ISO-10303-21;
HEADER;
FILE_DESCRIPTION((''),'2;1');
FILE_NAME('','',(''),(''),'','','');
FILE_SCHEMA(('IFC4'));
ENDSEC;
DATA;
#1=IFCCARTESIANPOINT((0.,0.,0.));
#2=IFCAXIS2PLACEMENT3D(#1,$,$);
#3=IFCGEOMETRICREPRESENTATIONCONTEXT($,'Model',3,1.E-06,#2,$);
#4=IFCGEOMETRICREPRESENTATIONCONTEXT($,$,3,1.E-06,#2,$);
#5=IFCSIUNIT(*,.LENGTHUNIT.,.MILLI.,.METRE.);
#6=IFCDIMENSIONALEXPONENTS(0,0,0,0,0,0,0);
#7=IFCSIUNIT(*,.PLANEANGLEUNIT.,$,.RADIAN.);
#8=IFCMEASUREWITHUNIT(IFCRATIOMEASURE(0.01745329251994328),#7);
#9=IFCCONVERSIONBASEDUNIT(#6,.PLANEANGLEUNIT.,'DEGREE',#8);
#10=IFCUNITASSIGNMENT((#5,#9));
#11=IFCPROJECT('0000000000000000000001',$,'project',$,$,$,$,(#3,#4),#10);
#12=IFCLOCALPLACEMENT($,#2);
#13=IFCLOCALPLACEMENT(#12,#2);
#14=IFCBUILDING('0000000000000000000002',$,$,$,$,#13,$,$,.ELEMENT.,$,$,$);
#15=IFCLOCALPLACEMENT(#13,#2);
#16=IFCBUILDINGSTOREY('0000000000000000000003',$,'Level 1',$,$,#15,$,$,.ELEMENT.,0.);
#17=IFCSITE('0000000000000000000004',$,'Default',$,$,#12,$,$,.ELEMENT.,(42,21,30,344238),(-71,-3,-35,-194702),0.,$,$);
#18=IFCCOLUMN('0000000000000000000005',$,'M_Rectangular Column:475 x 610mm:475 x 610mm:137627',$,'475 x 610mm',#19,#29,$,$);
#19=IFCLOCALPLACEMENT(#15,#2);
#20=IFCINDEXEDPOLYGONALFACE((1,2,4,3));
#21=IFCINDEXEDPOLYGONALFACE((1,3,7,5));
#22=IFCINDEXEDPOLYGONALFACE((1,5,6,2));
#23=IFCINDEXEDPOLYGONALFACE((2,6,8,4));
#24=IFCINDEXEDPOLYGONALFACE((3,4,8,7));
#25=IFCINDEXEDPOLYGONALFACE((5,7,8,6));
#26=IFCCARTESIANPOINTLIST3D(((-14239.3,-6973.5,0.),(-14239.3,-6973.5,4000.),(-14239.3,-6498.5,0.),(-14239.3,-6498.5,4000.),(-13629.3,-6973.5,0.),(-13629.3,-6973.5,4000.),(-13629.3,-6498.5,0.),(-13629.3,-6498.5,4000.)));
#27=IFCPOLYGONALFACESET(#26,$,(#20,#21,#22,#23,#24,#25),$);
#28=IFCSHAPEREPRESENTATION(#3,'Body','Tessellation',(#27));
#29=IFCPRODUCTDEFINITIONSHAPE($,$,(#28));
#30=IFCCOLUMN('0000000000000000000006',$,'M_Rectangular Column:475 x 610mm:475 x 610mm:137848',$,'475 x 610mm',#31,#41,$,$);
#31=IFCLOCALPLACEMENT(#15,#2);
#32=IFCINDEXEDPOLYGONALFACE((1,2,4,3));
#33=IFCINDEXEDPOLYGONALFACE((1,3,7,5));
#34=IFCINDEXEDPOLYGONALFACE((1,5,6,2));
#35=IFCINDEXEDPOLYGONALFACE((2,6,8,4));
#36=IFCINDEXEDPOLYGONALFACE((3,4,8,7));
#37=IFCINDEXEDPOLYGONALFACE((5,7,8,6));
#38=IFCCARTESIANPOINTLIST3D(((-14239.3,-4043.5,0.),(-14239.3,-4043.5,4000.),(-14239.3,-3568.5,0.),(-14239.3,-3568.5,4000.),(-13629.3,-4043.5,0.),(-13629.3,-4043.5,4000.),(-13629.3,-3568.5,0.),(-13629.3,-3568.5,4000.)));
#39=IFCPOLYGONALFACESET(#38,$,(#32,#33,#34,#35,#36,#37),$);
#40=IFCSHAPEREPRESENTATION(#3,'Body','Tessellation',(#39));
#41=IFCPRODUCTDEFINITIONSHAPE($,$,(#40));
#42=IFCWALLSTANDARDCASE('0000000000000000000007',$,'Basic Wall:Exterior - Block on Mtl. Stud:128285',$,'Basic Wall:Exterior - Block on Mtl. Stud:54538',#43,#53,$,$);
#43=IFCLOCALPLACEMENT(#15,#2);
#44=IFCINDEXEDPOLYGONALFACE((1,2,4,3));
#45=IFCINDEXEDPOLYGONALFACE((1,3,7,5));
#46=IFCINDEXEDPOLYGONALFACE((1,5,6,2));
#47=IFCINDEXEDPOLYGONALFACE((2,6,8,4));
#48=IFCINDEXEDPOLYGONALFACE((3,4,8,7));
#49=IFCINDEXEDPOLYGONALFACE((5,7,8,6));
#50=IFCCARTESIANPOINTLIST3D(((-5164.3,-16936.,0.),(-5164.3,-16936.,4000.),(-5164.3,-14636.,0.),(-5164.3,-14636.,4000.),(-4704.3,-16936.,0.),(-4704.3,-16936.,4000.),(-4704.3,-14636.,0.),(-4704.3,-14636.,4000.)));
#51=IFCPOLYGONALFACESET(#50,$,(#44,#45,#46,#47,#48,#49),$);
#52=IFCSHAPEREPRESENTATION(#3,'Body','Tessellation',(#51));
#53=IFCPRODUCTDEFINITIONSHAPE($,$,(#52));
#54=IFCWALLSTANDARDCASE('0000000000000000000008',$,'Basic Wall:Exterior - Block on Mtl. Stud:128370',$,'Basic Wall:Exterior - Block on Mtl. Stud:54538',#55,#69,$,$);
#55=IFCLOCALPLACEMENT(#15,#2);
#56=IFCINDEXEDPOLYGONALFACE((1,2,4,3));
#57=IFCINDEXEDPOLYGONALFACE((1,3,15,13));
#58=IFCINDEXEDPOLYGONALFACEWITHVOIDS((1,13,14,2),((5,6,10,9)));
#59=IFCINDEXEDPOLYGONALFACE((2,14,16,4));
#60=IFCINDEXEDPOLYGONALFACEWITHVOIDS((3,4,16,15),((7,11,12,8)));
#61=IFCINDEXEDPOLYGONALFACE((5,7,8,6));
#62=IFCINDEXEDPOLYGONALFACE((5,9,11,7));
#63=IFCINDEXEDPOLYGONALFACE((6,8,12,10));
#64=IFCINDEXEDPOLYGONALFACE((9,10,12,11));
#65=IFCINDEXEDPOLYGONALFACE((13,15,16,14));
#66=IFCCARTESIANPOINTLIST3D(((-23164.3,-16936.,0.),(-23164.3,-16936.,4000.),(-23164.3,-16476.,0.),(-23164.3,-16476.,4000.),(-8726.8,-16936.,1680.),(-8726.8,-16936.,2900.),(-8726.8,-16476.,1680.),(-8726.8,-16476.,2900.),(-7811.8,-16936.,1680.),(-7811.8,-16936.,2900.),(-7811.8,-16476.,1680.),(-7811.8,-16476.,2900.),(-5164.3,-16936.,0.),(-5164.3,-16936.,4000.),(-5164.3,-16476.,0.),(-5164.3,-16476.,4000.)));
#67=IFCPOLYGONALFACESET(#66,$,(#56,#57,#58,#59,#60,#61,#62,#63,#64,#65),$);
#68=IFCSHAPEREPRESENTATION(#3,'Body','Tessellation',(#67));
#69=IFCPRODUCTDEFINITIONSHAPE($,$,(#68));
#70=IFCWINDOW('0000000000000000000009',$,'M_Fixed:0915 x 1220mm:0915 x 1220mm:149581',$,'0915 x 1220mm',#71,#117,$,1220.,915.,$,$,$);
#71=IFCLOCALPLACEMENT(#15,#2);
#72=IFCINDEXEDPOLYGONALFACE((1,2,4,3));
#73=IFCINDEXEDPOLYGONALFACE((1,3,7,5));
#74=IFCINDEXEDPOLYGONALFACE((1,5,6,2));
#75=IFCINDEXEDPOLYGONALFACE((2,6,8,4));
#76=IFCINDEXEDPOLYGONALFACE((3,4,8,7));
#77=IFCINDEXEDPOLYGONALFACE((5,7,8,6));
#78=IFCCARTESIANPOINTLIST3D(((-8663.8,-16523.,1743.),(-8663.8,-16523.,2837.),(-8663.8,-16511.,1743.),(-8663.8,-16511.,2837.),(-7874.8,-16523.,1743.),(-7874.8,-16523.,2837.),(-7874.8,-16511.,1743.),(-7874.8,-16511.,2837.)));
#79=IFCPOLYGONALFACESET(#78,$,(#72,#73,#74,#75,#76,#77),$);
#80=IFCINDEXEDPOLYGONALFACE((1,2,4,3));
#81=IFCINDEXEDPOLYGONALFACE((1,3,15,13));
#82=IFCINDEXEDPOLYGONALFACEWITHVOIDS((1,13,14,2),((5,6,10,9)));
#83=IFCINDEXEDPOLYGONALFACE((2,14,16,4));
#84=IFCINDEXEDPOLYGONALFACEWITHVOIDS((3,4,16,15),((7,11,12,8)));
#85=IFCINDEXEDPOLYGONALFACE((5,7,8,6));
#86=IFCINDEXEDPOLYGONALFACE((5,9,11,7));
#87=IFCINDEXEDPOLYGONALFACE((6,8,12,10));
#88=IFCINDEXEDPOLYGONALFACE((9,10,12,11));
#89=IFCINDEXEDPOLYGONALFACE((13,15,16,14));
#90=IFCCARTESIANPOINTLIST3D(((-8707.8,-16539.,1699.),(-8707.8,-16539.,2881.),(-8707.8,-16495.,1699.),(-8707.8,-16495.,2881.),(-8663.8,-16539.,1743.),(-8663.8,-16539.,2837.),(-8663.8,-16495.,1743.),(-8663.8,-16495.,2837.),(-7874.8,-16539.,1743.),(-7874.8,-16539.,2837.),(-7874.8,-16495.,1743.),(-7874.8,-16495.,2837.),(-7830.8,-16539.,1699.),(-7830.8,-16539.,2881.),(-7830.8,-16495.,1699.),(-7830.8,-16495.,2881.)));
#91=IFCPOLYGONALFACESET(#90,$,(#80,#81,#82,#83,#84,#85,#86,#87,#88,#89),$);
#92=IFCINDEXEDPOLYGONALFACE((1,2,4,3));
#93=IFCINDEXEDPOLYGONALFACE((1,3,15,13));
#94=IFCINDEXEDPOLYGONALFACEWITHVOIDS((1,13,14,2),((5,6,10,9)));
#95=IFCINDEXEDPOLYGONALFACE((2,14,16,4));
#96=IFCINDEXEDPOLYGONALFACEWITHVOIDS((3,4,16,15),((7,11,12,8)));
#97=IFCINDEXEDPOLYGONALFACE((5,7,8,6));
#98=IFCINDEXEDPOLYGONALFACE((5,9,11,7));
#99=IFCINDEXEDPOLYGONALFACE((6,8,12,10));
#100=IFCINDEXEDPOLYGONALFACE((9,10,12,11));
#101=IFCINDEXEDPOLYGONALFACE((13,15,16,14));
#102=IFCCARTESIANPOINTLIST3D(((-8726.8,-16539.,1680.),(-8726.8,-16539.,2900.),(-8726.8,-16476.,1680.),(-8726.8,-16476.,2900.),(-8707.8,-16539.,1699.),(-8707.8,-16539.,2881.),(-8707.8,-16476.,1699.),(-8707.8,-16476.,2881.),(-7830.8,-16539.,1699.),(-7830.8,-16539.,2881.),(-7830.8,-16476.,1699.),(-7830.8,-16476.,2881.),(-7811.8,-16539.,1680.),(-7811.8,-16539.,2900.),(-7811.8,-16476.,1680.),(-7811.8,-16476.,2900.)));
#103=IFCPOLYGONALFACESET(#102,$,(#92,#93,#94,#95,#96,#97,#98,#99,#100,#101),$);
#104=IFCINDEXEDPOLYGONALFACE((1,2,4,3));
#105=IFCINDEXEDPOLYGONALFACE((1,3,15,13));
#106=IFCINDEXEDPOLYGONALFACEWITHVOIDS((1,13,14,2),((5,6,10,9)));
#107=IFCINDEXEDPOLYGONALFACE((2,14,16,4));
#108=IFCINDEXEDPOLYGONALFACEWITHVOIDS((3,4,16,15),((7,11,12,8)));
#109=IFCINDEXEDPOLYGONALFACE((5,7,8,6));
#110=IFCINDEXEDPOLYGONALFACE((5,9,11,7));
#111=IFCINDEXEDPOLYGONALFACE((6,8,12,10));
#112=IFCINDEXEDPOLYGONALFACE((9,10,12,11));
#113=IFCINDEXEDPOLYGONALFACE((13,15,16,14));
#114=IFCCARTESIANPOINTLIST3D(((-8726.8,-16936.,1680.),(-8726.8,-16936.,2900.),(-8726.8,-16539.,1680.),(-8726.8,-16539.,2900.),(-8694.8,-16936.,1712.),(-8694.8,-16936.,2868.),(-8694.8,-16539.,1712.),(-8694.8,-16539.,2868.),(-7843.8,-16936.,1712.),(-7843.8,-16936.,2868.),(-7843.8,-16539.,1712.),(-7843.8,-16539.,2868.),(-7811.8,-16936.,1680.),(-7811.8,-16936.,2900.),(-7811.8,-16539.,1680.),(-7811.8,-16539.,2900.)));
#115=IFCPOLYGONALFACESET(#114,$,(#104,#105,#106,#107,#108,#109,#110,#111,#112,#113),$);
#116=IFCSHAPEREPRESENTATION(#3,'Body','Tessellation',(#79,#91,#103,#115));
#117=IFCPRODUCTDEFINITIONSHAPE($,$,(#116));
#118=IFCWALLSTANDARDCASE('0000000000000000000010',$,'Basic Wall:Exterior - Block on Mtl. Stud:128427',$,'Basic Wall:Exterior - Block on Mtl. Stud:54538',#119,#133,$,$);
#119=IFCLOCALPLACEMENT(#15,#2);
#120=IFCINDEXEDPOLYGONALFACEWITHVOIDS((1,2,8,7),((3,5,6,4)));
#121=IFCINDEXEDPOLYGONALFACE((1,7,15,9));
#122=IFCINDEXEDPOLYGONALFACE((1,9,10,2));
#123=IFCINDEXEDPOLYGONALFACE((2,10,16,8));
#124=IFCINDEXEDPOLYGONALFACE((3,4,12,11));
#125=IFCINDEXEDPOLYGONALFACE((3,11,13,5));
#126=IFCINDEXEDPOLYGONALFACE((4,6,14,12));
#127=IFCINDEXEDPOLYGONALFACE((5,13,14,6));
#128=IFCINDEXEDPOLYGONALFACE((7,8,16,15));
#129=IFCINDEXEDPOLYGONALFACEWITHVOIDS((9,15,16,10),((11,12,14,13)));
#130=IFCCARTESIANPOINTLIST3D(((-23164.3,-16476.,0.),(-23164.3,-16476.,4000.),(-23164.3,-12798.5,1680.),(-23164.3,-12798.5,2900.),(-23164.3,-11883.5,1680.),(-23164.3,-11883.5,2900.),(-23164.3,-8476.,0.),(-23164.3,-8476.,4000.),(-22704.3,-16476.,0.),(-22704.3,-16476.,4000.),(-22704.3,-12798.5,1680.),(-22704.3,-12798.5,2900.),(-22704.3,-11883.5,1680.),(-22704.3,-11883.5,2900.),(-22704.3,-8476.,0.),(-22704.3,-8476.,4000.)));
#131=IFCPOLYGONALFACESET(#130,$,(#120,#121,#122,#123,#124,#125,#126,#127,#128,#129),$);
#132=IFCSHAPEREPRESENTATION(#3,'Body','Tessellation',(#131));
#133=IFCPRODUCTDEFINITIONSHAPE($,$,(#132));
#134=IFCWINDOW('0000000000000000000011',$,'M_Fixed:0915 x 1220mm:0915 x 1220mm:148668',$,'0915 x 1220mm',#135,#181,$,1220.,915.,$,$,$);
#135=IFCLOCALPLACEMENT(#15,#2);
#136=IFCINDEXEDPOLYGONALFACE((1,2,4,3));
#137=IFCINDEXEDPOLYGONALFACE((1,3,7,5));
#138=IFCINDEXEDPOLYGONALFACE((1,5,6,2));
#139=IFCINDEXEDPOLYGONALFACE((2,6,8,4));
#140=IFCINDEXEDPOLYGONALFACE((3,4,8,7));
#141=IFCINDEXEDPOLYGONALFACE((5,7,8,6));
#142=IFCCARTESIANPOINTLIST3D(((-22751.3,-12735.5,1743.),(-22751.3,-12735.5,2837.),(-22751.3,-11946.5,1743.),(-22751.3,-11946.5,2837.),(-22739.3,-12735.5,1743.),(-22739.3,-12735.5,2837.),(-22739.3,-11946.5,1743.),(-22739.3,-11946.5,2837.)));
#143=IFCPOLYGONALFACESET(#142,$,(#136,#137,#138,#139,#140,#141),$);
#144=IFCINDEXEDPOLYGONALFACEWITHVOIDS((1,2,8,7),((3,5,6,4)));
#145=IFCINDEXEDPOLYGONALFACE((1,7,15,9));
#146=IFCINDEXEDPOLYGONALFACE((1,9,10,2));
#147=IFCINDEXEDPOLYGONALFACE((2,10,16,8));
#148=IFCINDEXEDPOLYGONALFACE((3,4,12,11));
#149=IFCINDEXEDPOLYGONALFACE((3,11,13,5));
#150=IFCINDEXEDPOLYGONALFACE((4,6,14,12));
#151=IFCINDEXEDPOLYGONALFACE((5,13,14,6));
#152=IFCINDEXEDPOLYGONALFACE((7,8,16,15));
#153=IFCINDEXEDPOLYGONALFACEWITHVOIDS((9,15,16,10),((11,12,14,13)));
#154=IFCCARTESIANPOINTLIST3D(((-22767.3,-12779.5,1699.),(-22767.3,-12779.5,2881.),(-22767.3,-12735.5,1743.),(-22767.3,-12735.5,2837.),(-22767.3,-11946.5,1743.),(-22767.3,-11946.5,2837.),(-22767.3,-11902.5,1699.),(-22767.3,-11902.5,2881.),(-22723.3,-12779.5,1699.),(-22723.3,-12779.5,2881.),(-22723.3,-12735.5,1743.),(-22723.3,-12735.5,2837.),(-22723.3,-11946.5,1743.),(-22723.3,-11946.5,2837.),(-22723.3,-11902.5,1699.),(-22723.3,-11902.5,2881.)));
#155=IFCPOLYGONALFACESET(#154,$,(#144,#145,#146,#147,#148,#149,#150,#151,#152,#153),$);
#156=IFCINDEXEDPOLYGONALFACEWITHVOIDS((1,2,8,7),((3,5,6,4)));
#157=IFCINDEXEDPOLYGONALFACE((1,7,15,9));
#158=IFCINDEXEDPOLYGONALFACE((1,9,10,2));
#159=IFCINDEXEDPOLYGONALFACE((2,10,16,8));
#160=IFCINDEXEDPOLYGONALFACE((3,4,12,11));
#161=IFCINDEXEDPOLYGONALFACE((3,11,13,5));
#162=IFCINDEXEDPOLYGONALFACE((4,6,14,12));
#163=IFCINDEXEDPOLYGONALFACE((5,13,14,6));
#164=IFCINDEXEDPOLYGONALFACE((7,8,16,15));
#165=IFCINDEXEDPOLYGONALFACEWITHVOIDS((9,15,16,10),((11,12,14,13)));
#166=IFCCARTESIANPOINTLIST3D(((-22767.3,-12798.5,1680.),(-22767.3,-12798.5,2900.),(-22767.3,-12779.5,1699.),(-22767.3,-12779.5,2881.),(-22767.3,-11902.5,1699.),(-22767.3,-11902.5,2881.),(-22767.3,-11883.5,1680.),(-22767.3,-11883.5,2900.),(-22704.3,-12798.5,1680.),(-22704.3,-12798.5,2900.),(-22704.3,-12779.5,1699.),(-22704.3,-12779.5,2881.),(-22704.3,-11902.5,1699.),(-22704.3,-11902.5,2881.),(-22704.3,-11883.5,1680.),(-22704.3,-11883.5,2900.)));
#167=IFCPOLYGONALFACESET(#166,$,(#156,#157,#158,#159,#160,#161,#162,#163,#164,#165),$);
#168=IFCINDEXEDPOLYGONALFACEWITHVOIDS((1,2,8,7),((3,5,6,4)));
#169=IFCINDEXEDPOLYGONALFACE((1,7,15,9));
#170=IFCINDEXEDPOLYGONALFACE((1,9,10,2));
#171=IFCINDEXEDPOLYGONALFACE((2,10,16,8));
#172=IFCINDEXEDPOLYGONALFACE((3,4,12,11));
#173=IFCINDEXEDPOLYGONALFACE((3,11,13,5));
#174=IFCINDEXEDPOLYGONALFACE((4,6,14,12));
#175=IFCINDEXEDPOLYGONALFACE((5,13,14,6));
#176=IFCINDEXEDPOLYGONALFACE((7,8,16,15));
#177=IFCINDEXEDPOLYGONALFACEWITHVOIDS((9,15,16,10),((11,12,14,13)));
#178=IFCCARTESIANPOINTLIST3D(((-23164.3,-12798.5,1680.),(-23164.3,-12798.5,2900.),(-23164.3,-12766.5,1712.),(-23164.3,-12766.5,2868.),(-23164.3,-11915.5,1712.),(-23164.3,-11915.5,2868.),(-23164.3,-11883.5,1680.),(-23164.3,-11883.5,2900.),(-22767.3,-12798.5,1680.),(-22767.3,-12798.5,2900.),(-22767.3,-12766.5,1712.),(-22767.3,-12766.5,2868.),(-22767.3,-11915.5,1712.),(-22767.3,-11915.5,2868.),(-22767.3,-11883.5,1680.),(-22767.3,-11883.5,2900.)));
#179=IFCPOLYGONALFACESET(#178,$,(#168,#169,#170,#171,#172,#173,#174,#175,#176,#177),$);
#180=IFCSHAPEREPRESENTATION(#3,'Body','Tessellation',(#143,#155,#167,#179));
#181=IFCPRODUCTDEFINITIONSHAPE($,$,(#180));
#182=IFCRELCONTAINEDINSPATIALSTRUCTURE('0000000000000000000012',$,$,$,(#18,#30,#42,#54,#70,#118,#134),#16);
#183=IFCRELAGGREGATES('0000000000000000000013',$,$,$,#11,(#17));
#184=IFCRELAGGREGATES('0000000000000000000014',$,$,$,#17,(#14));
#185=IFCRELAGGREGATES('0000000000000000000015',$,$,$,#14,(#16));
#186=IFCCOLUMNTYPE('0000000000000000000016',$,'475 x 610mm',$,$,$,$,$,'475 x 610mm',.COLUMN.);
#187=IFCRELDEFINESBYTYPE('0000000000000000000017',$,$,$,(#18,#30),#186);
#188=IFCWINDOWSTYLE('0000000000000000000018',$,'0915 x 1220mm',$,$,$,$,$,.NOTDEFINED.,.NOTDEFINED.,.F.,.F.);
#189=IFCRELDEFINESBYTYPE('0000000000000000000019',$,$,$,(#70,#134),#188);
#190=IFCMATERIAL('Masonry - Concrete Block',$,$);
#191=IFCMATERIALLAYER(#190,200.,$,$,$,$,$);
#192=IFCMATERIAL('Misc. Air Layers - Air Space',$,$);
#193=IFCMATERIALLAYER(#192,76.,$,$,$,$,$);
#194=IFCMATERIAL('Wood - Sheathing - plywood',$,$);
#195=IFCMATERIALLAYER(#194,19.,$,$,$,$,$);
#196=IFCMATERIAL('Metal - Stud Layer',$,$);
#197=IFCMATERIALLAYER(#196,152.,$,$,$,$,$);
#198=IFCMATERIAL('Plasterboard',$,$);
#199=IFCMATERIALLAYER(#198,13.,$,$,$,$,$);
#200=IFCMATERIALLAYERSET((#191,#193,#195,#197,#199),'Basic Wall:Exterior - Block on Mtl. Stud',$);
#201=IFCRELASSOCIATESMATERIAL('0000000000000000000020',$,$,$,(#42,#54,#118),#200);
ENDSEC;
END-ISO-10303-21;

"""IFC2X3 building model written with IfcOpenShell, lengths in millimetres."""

from ifc_helpers import new_model, entity, si_unit, converted_unit, frame, frame_2d, origin, origin_2d_with_axis, place, context, project, spatial, polyline, rectangle, outline, extrude, source, transform, mapped, material, layer, layer_set, layer_usage, type_object, type_shapes, element, fill, save


model = new_model("IFC2X3")

# Units and contexts
model_context = context("Model", 3, precision=1e-06, world=origin())
context_of_model = context(None, 3, precision=1e-06, world=origin())
ifc_project = project(units=[si_unit("LENGTHUNIT", "METRE", prefix="MILLI"), converted_unit("PLANEANGLEUNIT", "DEGREE", entity("IfcRatioMeasure", 0.01745329251994328), si_unit("PLANEANGLEUNIT", "RADIAN"), dimensions=[0, 0, 0, 0, 0, 0, 0])], contexts=[model_context, context_of_model])

# Site, building, storey
site_placement = place(None, origin())
site = spatial("IfcSite", under=ifc_project, at=site_placement, Name="Default", CompositionType="ELEMENT", RefLatitude=(42, 21, 30, 344238), RefLongitude=(-71, -3, -35, -194702), RefElevation=0.0)
building_placement = place(site_placement, origin())
building = spatial("IfcBuilding", under=site, at=building_placement, CompositionType="ELEMENT")
storey_placement = place(building_placement, origin())
storey = spatial("IfcBuildingStorey", under=building, at=storey_placement, Name="Level 1", CompositionType="ELEMENT", Elevation=0.0)

# Columns
column_type = type_object("IfcColumnType", Name="475 x 610mm", ElementType="475 x 610mm", PredefinedType="COLUMN")
shared_shape_1 = source(origin(), model_context, "Body", "SweptSolid", [
    extrude(rectangle(XDim=475.0, YDim=610.0, at=frame_2d((0.0, 0.0), x_axis=(0.0, -1.0))), origin(), (0.0, 0.0, 1.0), 4000.0),
])
type_shapes(column_type, [shared_shape_1])
for number, where, name in (
    (1, (-13934.3, -6736.0, 0.0), "M_Rectangular Column:475 x 610mm:475 x 610mm:137627"),
    (2, (-13934.3, -3806.0, 0.0), "M_Rectangular Column:475 x 610mm:475 x 610mm:137848"),
):
    element("IfcColumn", number, at=place(storey_placement, frame(where)), inside=storey, type_object=column_type, Name=name, ObjectType="475 x 610mm", context=model_context, shape_type="MappedRepresentation", body=[
        mapped(shared_shape_1, transform((0.0, 0.0, 0.0), scale=1.0)),
    ])

# Wall
ifc_material_1 = material(Name="Masonry - Concrete Block")
ifc_layer_1 = layer(ifc_material_1, 200.0)
ifc_material_2 = material(Name="Misc. Air Layers - Air Space")
ifc_layer_2 = layer(ifc_material_2, 76.0)
ifc_material_3 = material(Name="Wood - Sheathing - plywood")
ifc_layer_3 = layer(ifc_material_3, 19.0)
ifc_material_4 = material(Name="Metal - Stud Layer")
ifc_layer_4 = layer(ifc_material_4, 152.0)
ifc_material_5 = material(Name="Plasterboard")
ifc_layer_5 = layer(ifc_material_5, 13.0)
ifc_layer_set_1 = layer_set([ifc_layer_1, ifc_layer_2, ifc_layer_3, ifc_layer_4, ifc_layer_5], Name="Basic Wall:Exterior - Block on Mtl. Stud")
ifc_layer_usage_1 = layer_usage(ifc_layer_set_1, "AXIS2", "NEGATIVE", 230.0)
wall_1_placement = place(storey_placement, frame((-4934.3, -14636.0, 0.0), z_axis=(0.0, 0.0, 1.0), x_axis=(0.0, -1.0, 0.0)))
element("IfcWallStandardCase", 3, at=wall_1_placement, inside=storey, material=ifc_layer_usage_1, Name="Basic Wall:Exterior - Block on Mtl. Stud:128285", ObjectType="Basic Wall:Exterior - Block on Mtl. Stud:54538", context=model_context, shape_type="SweptSolid", body=[
    extrude(rectangle(XDim=2300.0, YDim=460.0, at=frame_2d((1150.0, 0.0), x_axis=(-1.0, 0.0))), origin(), (0.0, 0.0, 1.0), 4000.0),
])

# Walls, openings, windows
ifc_layer_usage_2 = layer_usage(ifc_layer_set_1, "AXIS2", "NEGATIVE", 230.0)
wall_2_placement = place(storey_placement, frame((-5164.3, -16706.0, 0.0), z_axis=(0.0, 0.0, 1.0), x_axis=(-1.0, 0.0, 0.0)))
wall_2 = element("IfcWallStandardCase", 4, at=wall_2_placement, inside=storey, material=ifc_layer_usage_2, Name="Basic Wall:Exterior - Block on Mtl. Stud:128370", ObjectType="Basic Wall:Exterior - Block on Mtl. Stud:54538", context=model_context, shape_type="SweptSolid", body=[
    extrude(rectangle(XDim=18000.0, YDim=460.0, at=frame_2d((9000.0, 0.0), x_axis=(-1.0, 0.0))), origin(), (0.0, 0.0, 1.0), 4000.0),
])
opening_1_placement = place(wall_2_placement, frame((2647.5, -230.0, 1680.0)))
opening_1 = element("IfcOpeningElement", 5, at=opening_1_placement, cuts=wall_2, ObjectType="Opening", context=model_context, shape_type="SweptSolid", body=[
    extrude(rectangle(XDim=1220.0, YDim=915.0, at=frame_2d((610.0, 457.5), x_axis=(1.0, 0.0))), frame((0.0, 0.0, 0.0), z_axis=(0.0, 1.0, 0.0), x_axis=(0.0, 0.0, 1.0)), (0.0, 0.0, 1.0), 460.0),
])
window_style = type_object("IfcWindowStyle", Name="0915 x 1220mm", ConstructionType="NOTDEFINED", OperationType="NOTDEFINED", ParameterTakesPrecedence=False, Sizeable=False)
shared_shape_2 = source(origin(), model_context, "Body", "SweptSolid", [
    extrude(rectangle(XDim=12.0, YDim=789.0, at=origin_2d_with_axis()), frame((457.5, 419.0, 63.0), z_axis=(0.0, 0.0, 1.0), x_axis=(0.0, -1.0, 0.0)), (0.0, 0.0, 1.0), 1094.0),
    extrude(outline(polyline([(-438.5, -591.0), (438.5, -591.0), (438.5, 591.0), (-438.5, 591.0), (-438.5, -591.0)]), holes=[polyline([(-394.5, -547.0), (-394.5, 547.0), (394.5, 547.0), (394.5, -547.0), (-394.5, -547.0)])]), frame((457.5, 397.0, 610.0), z_axis=(0.0, 1.0, 0.0), x_axis=(1.0, 0.0, 0.0)), (0.0, 0.0, 1.0), 44.0),
    extrude(outline(polyline([(-457.5, -610.0), (457.5, -610.0), (457.5, 610.0), (-457.5, 610.0), (-457.5, -610.0)]), holes=[polyline([(-438.5, -591.0), (-438.5, 591.0), (438.5, 591.0), (438.5, -591.0), (-438.5, -591.0)])]), frame((457.5, 397.0, 610.0), z_axis=(0.0, 1.0, 0.0), x_axis=(1.0, 0.0, 0.0)), (0.0, 0.0, 1.0), 63.0),
    extrude(outline(polyline([(-457.5, -610.0), (457.5, -610.0), (457.5, 610.0), (-457.5, 610.0), (-457.5, -610.0)]), holes=[polyline([(-425.5, -578.0), (-425.5, 578.0), (425.5, 578.0), (425.5, -578.0), (-425.5, -578.0)])]), frame((457.5, 0.0, 610.0), z_axis=(0.0, 1.0, 0.0), x_axis=(1.0, 0.0, 0.0)), (0.0, 0.0, 1.0), 397.0),
])
type_shapes(window_style, [shared_shape_2])
window_1_placement = place(opening_1_placement, frame((915.0, 460.0, 0.0), z_axis=(0.0, 0.0, 1.0), x_axis=(-1.0, 0.0, 0.0)))
window_1 = element("IfcWindow", 6, at=window_1_placement, inside=storey, type_object=window_style, Name="M_Fixed:0915 x 1220mm:0915 x 1220mm:149581", ObjectType="0915 x 1220mm", OverallHeight=1220.0, OverallWidth=915.0, context=model_context, shape_type="MappedRepresentation", body=[
    mapped(shared_shape_2, transform((0.0, 0.0, 0.0), scale=1.0)),
])
fill(opening_1, window_1)
ifc_layer_usage_3 = layer_usage(ifc_layer_set_1, "AXIS2", "NEGATIVE", 230.0)
wall_3_placement = place(storey_placement, frame((-22934.3, -16476.0, 0.0), z_axis=(0.0, 0.0, 1.0), x_axis=(0.0, 1.0, 0.0)))
wall_3 = element("IfcWallStandardCase", 7, at=wall_3_placement, inside=storey, material=ifc_layer_usage_3, Name="Basic Wall:Exterior - Block on Mtl. Stud:128427", ObjectType="Basic Wall:Exterior - Block on Mtl. Stud:54538", context=model_context, shape_type="SweptSolid", body=[
    extrude(rectangle(XDim=8000.0, YDim=460.0, at=frame_2d((4000.0, 0.0), x_axis=(-1.0, 0.0))), origin(), (0.0, 0.0, 1.0), 4000.0),
])
opening_2_placement = place(wall_3_placement, frame((3677.5, -230.0, 1680.0)))
opening_2 = element("IfcOpeningElement", 8, at=opening_2_placement, cuts=wall_3, ObjectType="Opening", context=model_context, shape_type="SweptSolid", body=[
    extrude(rectangle(XDim=1220.0, YDim=915.0, at=frame_2d((610.0, 457.5), x_axis=(1.0, 0.0))), frame((0.0, 0.0, 0.0), z_axis=(0.0, 1.0, 0.0), x_axis=(0.0, 0.0, 1.0)), (0.0, 0.0, 1.0), 460.0),
])
window_2_placement = place(opening_2_placement, frame((915.0, 460.0, 0.0), z_axis=(0.0, 0.0, 1.0), x_axis=(-1.0, 0.0, 0.0)))
window_2 = element("IfcWindow", 9, at=window_2_placement, inside=storey, type_object=window_style, Name="M_Fixed:0915 x 1220mm:0915 x 1220mm:148668", ObjectType="0915 x 1220mm", OverallHeight=1220.0, OverallWidth=915.0, context=model_context, shape_type="MappedRepresentation", body=[
    mapped(shared_shape_2, transform((0.0, 0.0, 0.0), scale=1.0)),
])
fill(opening_2, window_2)

save(model, "model.ifc")
